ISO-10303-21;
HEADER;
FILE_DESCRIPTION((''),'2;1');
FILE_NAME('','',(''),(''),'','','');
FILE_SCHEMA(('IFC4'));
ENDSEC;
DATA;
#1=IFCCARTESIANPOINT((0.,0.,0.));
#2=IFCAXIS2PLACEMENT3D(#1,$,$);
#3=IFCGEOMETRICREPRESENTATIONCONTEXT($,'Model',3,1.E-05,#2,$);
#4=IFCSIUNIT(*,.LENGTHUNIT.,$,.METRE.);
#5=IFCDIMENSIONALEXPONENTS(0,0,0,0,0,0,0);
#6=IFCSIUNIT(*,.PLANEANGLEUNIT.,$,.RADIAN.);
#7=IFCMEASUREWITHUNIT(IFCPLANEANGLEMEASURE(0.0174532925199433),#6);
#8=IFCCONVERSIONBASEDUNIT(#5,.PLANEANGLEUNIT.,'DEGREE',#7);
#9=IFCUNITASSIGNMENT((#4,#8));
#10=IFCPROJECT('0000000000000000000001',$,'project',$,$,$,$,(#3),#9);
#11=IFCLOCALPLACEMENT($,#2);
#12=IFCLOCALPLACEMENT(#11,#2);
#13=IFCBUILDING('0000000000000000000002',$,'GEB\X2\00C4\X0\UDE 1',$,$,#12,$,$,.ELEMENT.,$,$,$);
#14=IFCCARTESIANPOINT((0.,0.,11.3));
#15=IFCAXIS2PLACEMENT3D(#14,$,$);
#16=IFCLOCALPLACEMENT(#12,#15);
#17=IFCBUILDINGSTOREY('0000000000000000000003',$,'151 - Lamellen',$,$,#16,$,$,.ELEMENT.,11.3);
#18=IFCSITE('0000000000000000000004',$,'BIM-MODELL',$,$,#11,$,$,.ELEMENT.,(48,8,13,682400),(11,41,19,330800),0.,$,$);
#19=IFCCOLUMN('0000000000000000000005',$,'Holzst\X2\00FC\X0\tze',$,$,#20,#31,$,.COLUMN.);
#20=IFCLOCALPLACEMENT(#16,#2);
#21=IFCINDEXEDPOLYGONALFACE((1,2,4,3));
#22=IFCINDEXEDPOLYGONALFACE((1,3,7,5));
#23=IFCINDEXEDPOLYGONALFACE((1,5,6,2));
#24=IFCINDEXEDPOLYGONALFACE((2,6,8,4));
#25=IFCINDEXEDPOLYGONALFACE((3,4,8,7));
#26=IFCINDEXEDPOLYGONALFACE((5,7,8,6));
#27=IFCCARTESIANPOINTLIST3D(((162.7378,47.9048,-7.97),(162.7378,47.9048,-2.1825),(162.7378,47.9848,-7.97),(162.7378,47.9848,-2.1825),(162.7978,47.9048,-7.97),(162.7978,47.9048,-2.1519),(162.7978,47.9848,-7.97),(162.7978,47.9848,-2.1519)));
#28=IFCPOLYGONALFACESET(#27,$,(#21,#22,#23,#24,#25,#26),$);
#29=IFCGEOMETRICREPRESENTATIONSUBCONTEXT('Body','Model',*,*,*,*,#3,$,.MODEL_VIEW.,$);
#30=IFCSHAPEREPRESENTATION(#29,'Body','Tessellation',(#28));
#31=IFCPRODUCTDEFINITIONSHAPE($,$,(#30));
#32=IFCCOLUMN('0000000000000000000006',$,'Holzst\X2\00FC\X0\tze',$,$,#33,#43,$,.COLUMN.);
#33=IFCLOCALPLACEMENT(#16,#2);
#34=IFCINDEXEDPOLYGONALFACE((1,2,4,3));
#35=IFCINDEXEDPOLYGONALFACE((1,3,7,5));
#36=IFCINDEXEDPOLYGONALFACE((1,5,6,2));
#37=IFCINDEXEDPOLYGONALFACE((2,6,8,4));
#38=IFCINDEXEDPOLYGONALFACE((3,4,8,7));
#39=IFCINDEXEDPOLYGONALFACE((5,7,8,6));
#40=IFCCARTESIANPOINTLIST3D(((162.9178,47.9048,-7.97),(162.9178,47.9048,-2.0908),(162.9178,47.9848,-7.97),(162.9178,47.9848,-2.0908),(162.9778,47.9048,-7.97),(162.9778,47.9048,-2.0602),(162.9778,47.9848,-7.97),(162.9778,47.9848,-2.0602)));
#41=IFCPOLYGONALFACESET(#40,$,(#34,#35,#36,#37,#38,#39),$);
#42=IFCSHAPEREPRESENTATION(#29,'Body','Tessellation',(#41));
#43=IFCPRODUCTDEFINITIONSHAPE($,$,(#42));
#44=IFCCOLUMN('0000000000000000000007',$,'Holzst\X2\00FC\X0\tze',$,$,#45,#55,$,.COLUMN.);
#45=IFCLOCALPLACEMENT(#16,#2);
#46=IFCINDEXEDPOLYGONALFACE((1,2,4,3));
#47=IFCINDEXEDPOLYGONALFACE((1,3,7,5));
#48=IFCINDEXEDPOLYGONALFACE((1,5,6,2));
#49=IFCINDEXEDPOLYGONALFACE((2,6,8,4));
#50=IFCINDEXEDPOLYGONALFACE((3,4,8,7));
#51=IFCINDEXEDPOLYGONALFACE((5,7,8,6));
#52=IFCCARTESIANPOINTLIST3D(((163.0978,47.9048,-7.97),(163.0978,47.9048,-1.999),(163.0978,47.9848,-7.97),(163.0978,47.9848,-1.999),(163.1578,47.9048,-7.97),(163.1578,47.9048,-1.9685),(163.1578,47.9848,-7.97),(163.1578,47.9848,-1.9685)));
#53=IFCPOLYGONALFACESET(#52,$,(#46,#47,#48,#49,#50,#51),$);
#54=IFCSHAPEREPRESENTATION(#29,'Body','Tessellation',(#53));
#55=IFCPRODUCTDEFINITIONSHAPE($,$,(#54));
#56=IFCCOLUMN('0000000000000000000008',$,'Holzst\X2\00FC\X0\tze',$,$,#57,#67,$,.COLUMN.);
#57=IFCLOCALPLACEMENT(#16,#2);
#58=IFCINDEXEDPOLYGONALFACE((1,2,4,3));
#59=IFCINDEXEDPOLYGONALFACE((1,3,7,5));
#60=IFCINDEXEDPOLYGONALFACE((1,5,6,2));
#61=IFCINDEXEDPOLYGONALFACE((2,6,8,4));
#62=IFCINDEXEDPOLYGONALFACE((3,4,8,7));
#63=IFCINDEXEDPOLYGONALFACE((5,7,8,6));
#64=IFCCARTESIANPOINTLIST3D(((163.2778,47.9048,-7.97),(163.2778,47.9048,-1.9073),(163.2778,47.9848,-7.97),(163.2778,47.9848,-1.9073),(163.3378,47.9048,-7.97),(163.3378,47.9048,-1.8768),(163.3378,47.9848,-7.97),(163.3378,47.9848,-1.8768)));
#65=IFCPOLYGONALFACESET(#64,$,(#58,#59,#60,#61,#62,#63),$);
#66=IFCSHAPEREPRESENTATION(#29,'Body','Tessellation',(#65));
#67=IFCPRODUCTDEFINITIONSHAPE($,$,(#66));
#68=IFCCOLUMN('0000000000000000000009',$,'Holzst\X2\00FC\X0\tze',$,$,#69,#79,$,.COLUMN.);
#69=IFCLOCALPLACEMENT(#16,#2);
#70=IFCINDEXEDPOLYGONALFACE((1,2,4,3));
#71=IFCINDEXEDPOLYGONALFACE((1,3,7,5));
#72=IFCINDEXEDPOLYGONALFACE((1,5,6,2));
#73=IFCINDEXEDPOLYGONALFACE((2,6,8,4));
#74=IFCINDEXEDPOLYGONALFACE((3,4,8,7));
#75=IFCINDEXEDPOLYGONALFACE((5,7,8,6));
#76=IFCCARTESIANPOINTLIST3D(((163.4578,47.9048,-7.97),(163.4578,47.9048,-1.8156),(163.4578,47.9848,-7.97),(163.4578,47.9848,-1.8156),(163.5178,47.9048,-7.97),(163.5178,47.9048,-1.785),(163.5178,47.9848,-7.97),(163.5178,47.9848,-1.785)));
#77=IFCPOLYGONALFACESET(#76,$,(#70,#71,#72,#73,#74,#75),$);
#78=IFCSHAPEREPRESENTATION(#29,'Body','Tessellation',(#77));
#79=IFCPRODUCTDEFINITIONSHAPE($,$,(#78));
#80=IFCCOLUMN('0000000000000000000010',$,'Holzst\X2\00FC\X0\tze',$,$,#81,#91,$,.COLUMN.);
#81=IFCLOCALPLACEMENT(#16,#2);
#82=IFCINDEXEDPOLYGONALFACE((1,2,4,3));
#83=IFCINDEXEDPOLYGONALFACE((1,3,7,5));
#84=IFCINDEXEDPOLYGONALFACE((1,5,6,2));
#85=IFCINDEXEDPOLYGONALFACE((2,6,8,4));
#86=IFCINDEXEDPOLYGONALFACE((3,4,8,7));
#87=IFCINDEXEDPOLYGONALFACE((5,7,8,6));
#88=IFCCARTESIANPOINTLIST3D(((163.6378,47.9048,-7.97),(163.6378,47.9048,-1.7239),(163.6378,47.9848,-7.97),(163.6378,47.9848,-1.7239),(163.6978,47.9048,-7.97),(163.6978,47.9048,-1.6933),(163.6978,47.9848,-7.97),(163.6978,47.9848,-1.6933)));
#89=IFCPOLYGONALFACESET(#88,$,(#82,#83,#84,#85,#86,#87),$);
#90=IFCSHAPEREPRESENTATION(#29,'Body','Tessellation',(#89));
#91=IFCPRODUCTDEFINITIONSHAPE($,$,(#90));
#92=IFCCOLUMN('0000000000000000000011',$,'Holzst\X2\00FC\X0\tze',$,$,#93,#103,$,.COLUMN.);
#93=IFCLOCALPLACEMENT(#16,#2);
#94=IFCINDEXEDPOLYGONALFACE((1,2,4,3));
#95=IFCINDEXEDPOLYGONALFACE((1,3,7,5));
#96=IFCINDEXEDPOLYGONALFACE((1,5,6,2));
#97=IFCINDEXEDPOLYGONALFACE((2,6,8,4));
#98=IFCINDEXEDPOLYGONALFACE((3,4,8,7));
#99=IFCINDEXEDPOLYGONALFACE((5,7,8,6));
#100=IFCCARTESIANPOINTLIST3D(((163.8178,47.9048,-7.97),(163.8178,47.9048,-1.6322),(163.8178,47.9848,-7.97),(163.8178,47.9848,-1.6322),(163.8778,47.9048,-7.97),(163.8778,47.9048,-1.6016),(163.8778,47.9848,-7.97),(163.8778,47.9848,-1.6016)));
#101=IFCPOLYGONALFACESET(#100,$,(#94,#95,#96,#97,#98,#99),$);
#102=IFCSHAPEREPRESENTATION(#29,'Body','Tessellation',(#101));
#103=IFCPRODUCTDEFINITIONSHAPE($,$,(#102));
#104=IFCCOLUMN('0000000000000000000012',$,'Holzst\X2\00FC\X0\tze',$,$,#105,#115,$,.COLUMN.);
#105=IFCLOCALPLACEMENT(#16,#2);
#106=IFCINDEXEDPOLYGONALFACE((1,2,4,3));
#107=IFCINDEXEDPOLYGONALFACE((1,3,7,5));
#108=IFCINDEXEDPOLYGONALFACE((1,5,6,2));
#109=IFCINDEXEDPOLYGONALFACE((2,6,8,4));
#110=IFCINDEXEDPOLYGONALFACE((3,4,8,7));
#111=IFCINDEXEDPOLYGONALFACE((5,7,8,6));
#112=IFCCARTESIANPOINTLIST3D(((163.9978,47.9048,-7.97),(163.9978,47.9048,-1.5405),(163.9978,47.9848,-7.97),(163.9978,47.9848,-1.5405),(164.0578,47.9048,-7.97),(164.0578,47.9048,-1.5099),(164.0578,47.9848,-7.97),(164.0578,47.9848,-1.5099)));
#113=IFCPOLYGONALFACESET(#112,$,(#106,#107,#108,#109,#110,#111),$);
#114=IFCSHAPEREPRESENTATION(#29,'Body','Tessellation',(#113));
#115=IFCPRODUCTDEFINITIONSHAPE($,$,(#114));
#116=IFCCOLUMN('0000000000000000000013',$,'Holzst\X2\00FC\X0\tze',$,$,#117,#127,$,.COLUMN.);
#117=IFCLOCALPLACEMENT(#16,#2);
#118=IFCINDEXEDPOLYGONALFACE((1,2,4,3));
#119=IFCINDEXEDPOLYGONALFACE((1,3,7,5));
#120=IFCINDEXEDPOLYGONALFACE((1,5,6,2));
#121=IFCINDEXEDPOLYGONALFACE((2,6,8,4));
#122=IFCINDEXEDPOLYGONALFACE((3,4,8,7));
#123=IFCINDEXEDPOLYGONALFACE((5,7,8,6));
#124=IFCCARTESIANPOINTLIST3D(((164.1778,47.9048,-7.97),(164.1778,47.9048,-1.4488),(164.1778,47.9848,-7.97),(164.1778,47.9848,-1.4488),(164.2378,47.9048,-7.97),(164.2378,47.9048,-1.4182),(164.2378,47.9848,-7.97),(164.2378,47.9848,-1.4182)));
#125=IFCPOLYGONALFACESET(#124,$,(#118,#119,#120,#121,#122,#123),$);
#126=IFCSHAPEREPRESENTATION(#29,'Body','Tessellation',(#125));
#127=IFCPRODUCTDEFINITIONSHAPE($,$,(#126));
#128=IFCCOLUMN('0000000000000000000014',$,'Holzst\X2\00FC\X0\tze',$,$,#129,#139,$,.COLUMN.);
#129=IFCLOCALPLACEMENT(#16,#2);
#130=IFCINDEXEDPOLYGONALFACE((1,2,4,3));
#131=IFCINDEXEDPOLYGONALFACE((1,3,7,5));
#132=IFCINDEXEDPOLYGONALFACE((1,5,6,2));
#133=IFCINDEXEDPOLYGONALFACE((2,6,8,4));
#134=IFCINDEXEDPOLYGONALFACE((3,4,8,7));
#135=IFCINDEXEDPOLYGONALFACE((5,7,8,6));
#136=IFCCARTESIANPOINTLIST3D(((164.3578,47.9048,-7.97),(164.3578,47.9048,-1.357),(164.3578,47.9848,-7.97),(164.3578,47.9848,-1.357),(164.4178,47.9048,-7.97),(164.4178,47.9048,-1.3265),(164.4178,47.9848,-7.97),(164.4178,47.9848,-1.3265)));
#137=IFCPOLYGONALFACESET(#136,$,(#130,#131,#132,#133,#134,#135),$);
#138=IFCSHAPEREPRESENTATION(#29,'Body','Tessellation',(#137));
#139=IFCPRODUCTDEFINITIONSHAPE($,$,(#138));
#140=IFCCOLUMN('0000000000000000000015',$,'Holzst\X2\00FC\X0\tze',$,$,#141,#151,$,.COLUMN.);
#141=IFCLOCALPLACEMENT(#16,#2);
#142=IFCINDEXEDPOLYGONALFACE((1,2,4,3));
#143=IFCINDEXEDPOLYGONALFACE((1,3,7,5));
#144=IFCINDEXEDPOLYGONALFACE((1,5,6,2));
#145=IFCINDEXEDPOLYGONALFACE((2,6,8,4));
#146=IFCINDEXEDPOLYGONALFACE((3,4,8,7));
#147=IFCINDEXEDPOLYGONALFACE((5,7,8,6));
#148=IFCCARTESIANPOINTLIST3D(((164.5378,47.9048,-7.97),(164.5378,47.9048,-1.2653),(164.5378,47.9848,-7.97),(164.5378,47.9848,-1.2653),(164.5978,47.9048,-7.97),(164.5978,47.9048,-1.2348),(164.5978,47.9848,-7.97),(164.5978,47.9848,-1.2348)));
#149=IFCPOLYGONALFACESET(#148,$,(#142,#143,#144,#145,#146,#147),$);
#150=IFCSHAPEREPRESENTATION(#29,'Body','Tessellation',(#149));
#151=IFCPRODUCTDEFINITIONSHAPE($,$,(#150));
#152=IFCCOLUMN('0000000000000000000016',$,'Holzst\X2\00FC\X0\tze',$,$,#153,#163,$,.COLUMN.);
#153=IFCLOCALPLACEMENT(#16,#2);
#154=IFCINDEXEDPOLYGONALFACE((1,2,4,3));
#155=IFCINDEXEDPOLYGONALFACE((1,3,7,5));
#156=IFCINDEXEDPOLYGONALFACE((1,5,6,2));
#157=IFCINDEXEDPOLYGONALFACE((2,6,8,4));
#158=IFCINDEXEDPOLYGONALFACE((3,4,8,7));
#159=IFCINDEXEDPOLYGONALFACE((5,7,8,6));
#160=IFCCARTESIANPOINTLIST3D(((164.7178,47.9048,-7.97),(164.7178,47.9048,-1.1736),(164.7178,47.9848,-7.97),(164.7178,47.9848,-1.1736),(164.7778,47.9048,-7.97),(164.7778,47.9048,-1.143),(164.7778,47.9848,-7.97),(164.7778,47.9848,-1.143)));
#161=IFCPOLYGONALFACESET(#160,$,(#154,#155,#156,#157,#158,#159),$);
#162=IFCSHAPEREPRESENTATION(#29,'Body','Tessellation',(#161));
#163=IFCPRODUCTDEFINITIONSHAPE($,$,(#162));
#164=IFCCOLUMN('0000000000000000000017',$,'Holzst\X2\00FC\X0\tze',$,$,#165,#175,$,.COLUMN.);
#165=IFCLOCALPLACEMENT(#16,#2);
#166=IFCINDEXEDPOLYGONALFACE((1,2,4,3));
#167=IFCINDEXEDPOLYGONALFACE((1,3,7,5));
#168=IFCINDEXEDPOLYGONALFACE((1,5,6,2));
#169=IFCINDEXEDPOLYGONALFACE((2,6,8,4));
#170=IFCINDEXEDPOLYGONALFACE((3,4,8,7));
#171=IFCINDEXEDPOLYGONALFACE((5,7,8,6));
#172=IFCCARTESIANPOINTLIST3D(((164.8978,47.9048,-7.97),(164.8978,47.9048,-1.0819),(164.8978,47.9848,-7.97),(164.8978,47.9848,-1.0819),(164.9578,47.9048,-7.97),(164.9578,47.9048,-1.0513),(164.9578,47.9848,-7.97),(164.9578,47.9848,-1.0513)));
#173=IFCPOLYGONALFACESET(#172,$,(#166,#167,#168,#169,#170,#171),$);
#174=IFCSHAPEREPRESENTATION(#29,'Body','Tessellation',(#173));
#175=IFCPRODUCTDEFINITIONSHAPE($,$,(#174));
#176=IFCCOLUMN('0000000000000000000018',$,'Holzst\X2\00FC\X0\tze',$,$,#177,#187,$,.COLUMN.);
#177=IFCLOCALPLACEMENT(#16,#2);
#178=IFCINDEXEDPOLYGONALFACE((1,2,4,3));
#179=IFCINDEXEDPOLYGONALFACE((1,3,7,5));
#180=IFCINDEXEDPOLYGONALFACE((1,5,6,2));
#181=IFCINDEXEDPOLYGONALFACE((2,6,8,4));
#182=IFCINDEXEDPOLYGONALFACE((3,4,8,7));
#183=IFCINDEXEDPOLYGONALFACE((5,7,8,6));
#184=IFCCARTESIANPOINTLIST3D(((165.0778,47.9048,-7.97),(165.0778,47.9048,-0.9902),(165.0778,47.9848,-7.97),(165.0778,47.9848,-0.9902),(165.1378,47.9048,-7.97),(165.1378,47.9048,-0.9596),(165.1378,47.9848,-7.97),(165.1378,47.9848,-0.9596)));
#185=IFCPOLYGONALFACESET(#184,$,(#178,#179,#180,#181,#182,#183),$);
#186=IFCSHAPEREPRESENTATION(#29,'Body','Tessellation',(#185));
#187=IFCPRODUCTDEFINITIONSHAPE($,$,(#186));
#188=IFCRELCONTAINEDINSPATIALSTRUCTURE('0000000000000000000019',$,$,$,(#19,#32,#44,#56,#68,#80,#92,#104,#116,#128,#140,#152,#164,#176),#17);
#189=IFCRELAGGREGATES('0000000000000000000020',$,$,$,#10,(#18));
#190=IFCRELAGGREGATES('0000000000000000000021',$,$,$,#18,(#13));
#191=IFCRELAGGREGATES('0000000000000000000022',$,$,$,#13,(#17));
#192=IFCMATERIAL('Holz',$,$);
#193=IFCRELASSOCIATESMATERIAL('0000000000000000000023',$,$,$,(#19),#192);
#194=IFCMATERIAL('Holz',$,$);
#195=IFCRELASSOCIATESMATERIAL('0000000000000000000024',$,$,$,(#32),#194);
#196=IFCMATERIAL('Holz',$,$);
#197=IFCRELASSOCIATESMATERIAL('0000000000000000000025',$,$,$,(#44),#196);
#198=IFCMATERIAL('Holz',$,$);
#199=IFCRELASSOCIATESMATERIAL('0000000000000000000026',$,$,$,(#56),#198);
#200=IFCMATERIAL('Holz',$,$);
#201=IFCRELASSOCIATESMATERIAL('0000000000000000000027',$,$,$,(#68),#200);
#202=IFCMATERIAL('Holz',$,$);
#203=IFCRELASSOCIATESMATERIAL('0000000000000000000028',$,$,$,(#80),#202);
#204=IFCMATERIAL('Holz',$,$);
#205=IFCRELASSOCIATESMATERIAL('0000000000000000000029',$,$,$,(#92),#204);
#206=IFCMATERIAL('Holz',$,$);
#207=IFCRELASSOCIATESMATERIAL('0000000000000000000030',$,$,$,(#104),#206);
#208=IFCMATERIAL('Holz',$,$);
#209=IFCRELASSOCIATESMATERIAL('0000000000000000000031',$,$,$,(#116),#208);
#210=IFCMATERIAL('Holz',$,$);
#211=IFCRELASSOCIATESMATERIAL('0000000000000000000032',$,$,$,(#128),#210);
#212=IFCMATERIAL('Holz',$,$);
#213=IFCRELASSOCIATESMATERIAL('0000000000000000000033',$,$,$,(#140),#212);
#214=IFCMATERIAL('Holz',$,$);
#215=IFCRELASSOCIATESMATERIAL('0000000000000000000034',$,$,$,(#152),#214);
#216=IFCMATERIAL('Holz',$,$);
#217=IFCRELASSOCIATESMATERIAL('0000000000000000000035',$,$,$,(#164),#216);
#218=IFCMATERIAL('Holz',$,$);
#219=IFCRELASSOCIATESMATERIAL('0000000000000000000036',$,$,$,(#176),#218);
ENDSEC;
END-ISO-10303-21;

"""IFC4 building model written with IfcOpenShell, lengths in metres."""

from ifc_helpers import new_model, entity, si_unit, converted_unit, frame, frame_2d, origin, origin_with_axes, place, context, subcontext, project, spatial, rectangle, extrude, clip, halfspace, material, element, save


model = new_model("IFC4")

# Units and contexts
model_context = context("Model", 3, precision=1e-05, world=origin())
body_context = subcontext(model_context, "Body", "Model", "MODEL_VIEW")
ifc_project = project(units=[si_unit("LENGTHUNIT", "METRE"), converted_unit("PLANEANGLEUNIT", "DEGREE", entity("IfcPlaneAngleMeasure", 0.0174532925199433), si_unit("PLANEANGLEUNIT", "RADIAN"), dimensions=[0, 0, 0, 0, 0, 0, 0])], contexts=[model_context])

# Site, building, storey
site_placement = place(None, origin())
site = spatial("IfcSite", under=ifc_project, at=site_placement, Name="BIM-MODELL", CompositionType="ELEMENT", RefLatitude=(48, 8, 13, 682400), RefLongitude=(11, 41, 19, 330800), RefElevation=0.0)
building_placement = place(site_placement, origin())
building = spatial("IfcBuilding", under=site, at=building_placement, Name="GEBÄUDE 1", CompositionType="ELEMENT")
storey_placement = place(building_placement, frame((0.0, 0.0, 11.3)))
storey = spatial("IfcBuildingStorey", under=building, at=storey_placement, Name="151 - Lamellen", CompositionType="ELEMENT", Elevation=11.3)

# Columns
ifc_material_1 = material(Name="Holz")
column_1_placement = place(storey_placement, frame((162.7378, 47.9048, -7.97)))
element("IfcColumn", 1, at=column_1_placement, inside=storey, material=ifc_material_1, Name="Holzstütze", PredefinedType="COLUMN", context=body_context, shape_type="Clipping", body=[
    clip(extrude(rectangle(XDim=0.06, YDim=0.08, at=frame_2d((0.03, 0.04), x_axis=(1.0, 0.0))), origin_with_axes(), (0.0, 0.0, 1.0), 5.8181), halfspace(frame((0.03, 0.04, 5.8028), z_axis=(0.45399, 0.0, -0.891007), x_axis=(0.0, 1.0, 0.0)), True)),
])
ifc_material_2 = material(Name="Holz")
column_2_placement = place(storey_placement, frame((162.9178, 47.9048, -7.97)))
element("IfcColumn", 2, at=column_2_placement, inside=storey, material=ifc_material_2, Name="Holzstütze", PredefinedType="COLUMN", context=body_context, shape_type="Clipping", body=[
    clip(extrude(rectangle(XDim=0.06, YDim=0.08, at=frame_2d((0.03, 0.04), x_axis=(1.0, 0.0))), origin_with_axes(), (0.0, 0.0, 1.0), 5.9098), halfspace(frame((0.03, 0.04, 5.8945), z_axis=(0.45399, 0.0, -0.891007), x_axis=(0.0, 1.0, 0.0)), True)),
])
ifc_material_3 = material(Name="Holz")
column_3_placement = place(storey_placement, frame((163.0978, 47.9048, -7.97)))
element("IfcColumn", 3, at=column_3_placement, inside=storey, material=ifc_material_3, Name="Holzstütze", PredefinedType="COLUMN", context=body_context, shape_type="Clipping", body=[
    clip(extrude(rectangle(XDim=0.06, YDim=0.08, at=frame_2d((0.03, 0.04), x_axis=(1.0, 0.0))), origin_with_axes(), (0.0, 0.0, 1.0), 6.0015), halfspace(frame((0.03, 0.04, 5.9862), z_axis=(0.45399, 0.0, -0.891007), x_axis=(0.0, 1.0, 0.0)), True)),
])
ifc_material_4 = material(Name="Holz")
column_4_placement = place(storey_placement, frame((163.2778, 47.9048, -7.97)))
element("IfcColumn", 4, at=column_4_placement, inside=storey, material=ifc_material_4, Name="Holzstütze", PredefinedType="COLUMN", context=body_context, shape_type="Clipping", body=[
    clip(extrude(rectangle(XDim=0.06, YDim=0.08, at=frame_2d((0.03, 0.04), x_axis=(1.0, 0.0))), origin_with_axes(), (0.0, 0.0, 1.0), 6.0932), halfspace(frame((0.03, 0.04, 6.078), z_axis=(0.45399, 0.0, -0.891007), x_axis=(0.0, 1.0, 0.0)), True)),
])
ifc_material_5 = material(Name="Holz")
column_5_placement = place(storey_placement, frame((163.4578, 47.9048, -7.97)))
element("IfcColumn", 5, at=column_5_placement, inside=storey, material=ifc_material_5, Name="Holzstütze", PredefinedType="COLUMN", context=body_context, shape_type="Clipping", body=[
    clip(extrude(rectangle(XDim=0.06, YDim=0.08, at=frame_2d((0.03, 0.04), x_axis=(1.0, 0.0))), origin_with_axes(), (0.0, 0.0, 1.0), 6.185), halfspace(frame((0.03, 0.04, 6.1697), z_axis=(0.45399, 0.0, -0.891007), x_axis=(0.0, 1.0, 0.0)), True)),
])
ifc_material_6 = material(Name="Holz")
column_6_placement = place(storey_placement, frame((163.6378, 47.9048, -7.97)))
element("IfcColumn", 6, at=column_6_placement, inside=storey, material=ifc_material_6, Name="Holzstütze", PredefinedType="COLUMN", context=body_context, shape_type="Clipping", body=[
    clip(extrude(rectangle(XDim=0.06, YDim=0.08, at=frame_2d((0.03, 0.04), x_axis=(1.0, 0.0))), origin_with_axes(), (0.0, 0.0, 1.0), 6.2767), halfspace(frame((0.03, 0.04, 6.2614), z_axis=(0.45399, 0.0, -0.891007), x_axis=(0.0, 1.0, 0.0)), True)),
])
ifc_material_7 = material(Name="Holz")
column_7_placement = place(storey_placement, frame((163.8178, 47.9048, -7.97)))
element("IfcColumn", 7, at=column_7_placement, inside=storey, material=ifc_material_7, Name="Holzstütze", PredefinedType="COLUMN", context=body_context, shape_type="Clipping", body=[
    clip(extrude(rectangle(XDim=0.06, YDim=0.08, at=frame_2d((0.03, 0.04), x_axis=(1.0, 0.0))), origin_with_axes(), (0.0, 0.0, 1.0), 6.3684), halfspace(frame((0.03, 0.04, 6.3531), z_axis=(0.45399, 0.0, -0.891007), x_axis=(0.0, 1.0, 0.0)), True)),
])
ifc_material_8 = material(Name="Holz")
column_8_placement = place(storey_placement, frame((163.9978, 47.9048, -7.97)))
element("IfcColumn", 8, at=column_8_placement, inside=storey, material=ifc_material_8, Name="Holzstütze", PredefinedType="COLUMN", context=body_context, shape_type="Clipping", body=[
    clip(extrude(rectangle(XDim=0.06, YDim=0.08, at=frame_2d((0.03, 0.04), x_axis=(1.0, 0.0))), origin_with_axes(), (0.0, 0.0, 1.0), 6.4601), halfspace(frame((0.03, 0.04, 6.4448), z_axis=(0.45399, 0.0, -0.891007), x_axis=(0.0, 1.0, 0.0)), True)),
])
ifc_material_9 = material(Name="Holz")
column_9_placement = place(storey_placement, frame((164.1778, 47.9048, -7.97)))
element("IfcColumn", 9, at=column_9_placement, inside=storey, material=ifc_material_9, Name="Holzstütze", PredefinedType="COLUMN", context=body_context, shape_type="Clipping", body=[
    clip(extrude(rectangle(XDim=0.06, YDim=0.08, at=frame_2d((0.03, 0.04), x_axis=(1.0, 0.0))), origin_with_axes(), (0.0, 0.0, 1.0), 6.5518), halfspace(frame((0.03, 0.04, 6.5365), z_axis=(0.45399, 0.0, -0.891007), x_axis=(0.0, 1.0, 0.0)), True)),
])
ifc_material_10 = material(Name="Holz")
column_10_placement = place(storey_placement, frame((164.3578, 47.9048, -7.97)))
element("IfcColumn", 10, at=column_10_placement, inside=storey, material=ifc_material_10, Name="Holzstütze", PredefinedType="COLUMN", context=body_context, shape_type="Clipping", body=[
    clip(extrude(rectangle(XDim=0.06, YDim=0.08, at=frame_2d((0.03, 0.04), x_axis=(1.0, 0.0))), origin_with_axes(), (0.0, 0.0, 1.0), 6.6435), halfspace(frame((0.03, 0.04, 6.6282), z_axis=(0.45399, 0.0, -0.891007), x_axis=(0.0, 1.0, 0.0)), True)),
])
ifc_material_11 = material(Name="Holz")
column_11_placement = place(storey_placement, frame((164.5378, 47.9048, -7.97)))
element("IfcColumn", 11, at=column_11_placement, inside=storey, material=ifc_material_11, Name="Holzstütze", PredefinedType="COLUMN", context=body_context, shape_type="Clipping", body=[
    clip(extrude(rectangle(XDim=0.06, YDim=0.08, at=frame_2d((0.03, 0.04), x_axis=(1.0, 0.0))), origin_with_axes(), (0.0, 0.0, 1.0), 6.7352), halfspace(frame((0.03, 0.04, 6.72), z_axis=(0.45399, 0.0, -0.891007), x_axis=(0.0, 1.0, 0.0)), True)),
])
ifc_material_12 = material(Name="Holz")
column_12_placement = place(storey_placement, frame((164.7178, 47.9048, -7.97)))
element("IfcColumn", 12, at=column_12_placement, inside=storey, material=ifc_material_12, Name="Holzstütze", PredefinedType="COLUMN", context=body_context, shape_type="Clipping", body=[
    clip(extrude(rectangle(XDim=0.06, YDim=0.08, at=frame_2d((0.03, 0.04), x_axis=(1.0, 0.0))), origin_with_axes(), (0.0, 0.0, 1.0), 6.827), halfspace(frame((0.03, 0.04, 6.8117), z_axis=(0.45399, 0.0, -0.891007), x_axis=(0.0, 1.0, 0.0)), True)),
])
ifc_material_13 = material(Name="Holz")
column_13_placement = place(storey_placement, frame((164.8978, 47.9048, -7.97)))
element("IfcColumn", 13, at=column_13_placement, inside=storey, material=ifc_material_13, Name="Holzstütze", PredefinedType="COLUMN", context=body_context, shape_type="Clipping", body=[
    clip(extrude(rectangle(XDim=0.06, YDim=0.08, at=frame_2d((0.03, 0.04), x_axis=(1.0, 0.0))), origin_with_axes(), (0.0, 0.0, 1.0), 6.9187), halfspace(frame((0.03, 0.04, 6.9034), z_axis=(0.45399, 0.0, -0.891007), x_axis=(0.0, 1.0, 0.0)), True)),
])
ifc_material_14 = material(Name="Holz")
column_14_placement = place(storey_placement, frame((165.0778, 47.9048, -7.97)))
element("IfcColumn", 14, at=column_14_placement, inside=storey, material=ifc_material_14, Name="Holzstütze", PredefinedType="COLUMN", context=body_context, shape_type="Clipping", body=[
    clip(extrude(rectangle(XDim=0.06, YDim=0.08, at=frame_2d((0.03, 0.04), x_axis=(1.0, 0.0))), origin_with_axes(), (0.0, 0.0, 1.0), 7.0104), halfspace(frame((0.03, 0.04, 6.9951), z_axis=(0.45399, 0.0, -0.891007), x_axis=(0.0, 1.0, 0.0)), True)),
])

save(model, "model.ifc")
